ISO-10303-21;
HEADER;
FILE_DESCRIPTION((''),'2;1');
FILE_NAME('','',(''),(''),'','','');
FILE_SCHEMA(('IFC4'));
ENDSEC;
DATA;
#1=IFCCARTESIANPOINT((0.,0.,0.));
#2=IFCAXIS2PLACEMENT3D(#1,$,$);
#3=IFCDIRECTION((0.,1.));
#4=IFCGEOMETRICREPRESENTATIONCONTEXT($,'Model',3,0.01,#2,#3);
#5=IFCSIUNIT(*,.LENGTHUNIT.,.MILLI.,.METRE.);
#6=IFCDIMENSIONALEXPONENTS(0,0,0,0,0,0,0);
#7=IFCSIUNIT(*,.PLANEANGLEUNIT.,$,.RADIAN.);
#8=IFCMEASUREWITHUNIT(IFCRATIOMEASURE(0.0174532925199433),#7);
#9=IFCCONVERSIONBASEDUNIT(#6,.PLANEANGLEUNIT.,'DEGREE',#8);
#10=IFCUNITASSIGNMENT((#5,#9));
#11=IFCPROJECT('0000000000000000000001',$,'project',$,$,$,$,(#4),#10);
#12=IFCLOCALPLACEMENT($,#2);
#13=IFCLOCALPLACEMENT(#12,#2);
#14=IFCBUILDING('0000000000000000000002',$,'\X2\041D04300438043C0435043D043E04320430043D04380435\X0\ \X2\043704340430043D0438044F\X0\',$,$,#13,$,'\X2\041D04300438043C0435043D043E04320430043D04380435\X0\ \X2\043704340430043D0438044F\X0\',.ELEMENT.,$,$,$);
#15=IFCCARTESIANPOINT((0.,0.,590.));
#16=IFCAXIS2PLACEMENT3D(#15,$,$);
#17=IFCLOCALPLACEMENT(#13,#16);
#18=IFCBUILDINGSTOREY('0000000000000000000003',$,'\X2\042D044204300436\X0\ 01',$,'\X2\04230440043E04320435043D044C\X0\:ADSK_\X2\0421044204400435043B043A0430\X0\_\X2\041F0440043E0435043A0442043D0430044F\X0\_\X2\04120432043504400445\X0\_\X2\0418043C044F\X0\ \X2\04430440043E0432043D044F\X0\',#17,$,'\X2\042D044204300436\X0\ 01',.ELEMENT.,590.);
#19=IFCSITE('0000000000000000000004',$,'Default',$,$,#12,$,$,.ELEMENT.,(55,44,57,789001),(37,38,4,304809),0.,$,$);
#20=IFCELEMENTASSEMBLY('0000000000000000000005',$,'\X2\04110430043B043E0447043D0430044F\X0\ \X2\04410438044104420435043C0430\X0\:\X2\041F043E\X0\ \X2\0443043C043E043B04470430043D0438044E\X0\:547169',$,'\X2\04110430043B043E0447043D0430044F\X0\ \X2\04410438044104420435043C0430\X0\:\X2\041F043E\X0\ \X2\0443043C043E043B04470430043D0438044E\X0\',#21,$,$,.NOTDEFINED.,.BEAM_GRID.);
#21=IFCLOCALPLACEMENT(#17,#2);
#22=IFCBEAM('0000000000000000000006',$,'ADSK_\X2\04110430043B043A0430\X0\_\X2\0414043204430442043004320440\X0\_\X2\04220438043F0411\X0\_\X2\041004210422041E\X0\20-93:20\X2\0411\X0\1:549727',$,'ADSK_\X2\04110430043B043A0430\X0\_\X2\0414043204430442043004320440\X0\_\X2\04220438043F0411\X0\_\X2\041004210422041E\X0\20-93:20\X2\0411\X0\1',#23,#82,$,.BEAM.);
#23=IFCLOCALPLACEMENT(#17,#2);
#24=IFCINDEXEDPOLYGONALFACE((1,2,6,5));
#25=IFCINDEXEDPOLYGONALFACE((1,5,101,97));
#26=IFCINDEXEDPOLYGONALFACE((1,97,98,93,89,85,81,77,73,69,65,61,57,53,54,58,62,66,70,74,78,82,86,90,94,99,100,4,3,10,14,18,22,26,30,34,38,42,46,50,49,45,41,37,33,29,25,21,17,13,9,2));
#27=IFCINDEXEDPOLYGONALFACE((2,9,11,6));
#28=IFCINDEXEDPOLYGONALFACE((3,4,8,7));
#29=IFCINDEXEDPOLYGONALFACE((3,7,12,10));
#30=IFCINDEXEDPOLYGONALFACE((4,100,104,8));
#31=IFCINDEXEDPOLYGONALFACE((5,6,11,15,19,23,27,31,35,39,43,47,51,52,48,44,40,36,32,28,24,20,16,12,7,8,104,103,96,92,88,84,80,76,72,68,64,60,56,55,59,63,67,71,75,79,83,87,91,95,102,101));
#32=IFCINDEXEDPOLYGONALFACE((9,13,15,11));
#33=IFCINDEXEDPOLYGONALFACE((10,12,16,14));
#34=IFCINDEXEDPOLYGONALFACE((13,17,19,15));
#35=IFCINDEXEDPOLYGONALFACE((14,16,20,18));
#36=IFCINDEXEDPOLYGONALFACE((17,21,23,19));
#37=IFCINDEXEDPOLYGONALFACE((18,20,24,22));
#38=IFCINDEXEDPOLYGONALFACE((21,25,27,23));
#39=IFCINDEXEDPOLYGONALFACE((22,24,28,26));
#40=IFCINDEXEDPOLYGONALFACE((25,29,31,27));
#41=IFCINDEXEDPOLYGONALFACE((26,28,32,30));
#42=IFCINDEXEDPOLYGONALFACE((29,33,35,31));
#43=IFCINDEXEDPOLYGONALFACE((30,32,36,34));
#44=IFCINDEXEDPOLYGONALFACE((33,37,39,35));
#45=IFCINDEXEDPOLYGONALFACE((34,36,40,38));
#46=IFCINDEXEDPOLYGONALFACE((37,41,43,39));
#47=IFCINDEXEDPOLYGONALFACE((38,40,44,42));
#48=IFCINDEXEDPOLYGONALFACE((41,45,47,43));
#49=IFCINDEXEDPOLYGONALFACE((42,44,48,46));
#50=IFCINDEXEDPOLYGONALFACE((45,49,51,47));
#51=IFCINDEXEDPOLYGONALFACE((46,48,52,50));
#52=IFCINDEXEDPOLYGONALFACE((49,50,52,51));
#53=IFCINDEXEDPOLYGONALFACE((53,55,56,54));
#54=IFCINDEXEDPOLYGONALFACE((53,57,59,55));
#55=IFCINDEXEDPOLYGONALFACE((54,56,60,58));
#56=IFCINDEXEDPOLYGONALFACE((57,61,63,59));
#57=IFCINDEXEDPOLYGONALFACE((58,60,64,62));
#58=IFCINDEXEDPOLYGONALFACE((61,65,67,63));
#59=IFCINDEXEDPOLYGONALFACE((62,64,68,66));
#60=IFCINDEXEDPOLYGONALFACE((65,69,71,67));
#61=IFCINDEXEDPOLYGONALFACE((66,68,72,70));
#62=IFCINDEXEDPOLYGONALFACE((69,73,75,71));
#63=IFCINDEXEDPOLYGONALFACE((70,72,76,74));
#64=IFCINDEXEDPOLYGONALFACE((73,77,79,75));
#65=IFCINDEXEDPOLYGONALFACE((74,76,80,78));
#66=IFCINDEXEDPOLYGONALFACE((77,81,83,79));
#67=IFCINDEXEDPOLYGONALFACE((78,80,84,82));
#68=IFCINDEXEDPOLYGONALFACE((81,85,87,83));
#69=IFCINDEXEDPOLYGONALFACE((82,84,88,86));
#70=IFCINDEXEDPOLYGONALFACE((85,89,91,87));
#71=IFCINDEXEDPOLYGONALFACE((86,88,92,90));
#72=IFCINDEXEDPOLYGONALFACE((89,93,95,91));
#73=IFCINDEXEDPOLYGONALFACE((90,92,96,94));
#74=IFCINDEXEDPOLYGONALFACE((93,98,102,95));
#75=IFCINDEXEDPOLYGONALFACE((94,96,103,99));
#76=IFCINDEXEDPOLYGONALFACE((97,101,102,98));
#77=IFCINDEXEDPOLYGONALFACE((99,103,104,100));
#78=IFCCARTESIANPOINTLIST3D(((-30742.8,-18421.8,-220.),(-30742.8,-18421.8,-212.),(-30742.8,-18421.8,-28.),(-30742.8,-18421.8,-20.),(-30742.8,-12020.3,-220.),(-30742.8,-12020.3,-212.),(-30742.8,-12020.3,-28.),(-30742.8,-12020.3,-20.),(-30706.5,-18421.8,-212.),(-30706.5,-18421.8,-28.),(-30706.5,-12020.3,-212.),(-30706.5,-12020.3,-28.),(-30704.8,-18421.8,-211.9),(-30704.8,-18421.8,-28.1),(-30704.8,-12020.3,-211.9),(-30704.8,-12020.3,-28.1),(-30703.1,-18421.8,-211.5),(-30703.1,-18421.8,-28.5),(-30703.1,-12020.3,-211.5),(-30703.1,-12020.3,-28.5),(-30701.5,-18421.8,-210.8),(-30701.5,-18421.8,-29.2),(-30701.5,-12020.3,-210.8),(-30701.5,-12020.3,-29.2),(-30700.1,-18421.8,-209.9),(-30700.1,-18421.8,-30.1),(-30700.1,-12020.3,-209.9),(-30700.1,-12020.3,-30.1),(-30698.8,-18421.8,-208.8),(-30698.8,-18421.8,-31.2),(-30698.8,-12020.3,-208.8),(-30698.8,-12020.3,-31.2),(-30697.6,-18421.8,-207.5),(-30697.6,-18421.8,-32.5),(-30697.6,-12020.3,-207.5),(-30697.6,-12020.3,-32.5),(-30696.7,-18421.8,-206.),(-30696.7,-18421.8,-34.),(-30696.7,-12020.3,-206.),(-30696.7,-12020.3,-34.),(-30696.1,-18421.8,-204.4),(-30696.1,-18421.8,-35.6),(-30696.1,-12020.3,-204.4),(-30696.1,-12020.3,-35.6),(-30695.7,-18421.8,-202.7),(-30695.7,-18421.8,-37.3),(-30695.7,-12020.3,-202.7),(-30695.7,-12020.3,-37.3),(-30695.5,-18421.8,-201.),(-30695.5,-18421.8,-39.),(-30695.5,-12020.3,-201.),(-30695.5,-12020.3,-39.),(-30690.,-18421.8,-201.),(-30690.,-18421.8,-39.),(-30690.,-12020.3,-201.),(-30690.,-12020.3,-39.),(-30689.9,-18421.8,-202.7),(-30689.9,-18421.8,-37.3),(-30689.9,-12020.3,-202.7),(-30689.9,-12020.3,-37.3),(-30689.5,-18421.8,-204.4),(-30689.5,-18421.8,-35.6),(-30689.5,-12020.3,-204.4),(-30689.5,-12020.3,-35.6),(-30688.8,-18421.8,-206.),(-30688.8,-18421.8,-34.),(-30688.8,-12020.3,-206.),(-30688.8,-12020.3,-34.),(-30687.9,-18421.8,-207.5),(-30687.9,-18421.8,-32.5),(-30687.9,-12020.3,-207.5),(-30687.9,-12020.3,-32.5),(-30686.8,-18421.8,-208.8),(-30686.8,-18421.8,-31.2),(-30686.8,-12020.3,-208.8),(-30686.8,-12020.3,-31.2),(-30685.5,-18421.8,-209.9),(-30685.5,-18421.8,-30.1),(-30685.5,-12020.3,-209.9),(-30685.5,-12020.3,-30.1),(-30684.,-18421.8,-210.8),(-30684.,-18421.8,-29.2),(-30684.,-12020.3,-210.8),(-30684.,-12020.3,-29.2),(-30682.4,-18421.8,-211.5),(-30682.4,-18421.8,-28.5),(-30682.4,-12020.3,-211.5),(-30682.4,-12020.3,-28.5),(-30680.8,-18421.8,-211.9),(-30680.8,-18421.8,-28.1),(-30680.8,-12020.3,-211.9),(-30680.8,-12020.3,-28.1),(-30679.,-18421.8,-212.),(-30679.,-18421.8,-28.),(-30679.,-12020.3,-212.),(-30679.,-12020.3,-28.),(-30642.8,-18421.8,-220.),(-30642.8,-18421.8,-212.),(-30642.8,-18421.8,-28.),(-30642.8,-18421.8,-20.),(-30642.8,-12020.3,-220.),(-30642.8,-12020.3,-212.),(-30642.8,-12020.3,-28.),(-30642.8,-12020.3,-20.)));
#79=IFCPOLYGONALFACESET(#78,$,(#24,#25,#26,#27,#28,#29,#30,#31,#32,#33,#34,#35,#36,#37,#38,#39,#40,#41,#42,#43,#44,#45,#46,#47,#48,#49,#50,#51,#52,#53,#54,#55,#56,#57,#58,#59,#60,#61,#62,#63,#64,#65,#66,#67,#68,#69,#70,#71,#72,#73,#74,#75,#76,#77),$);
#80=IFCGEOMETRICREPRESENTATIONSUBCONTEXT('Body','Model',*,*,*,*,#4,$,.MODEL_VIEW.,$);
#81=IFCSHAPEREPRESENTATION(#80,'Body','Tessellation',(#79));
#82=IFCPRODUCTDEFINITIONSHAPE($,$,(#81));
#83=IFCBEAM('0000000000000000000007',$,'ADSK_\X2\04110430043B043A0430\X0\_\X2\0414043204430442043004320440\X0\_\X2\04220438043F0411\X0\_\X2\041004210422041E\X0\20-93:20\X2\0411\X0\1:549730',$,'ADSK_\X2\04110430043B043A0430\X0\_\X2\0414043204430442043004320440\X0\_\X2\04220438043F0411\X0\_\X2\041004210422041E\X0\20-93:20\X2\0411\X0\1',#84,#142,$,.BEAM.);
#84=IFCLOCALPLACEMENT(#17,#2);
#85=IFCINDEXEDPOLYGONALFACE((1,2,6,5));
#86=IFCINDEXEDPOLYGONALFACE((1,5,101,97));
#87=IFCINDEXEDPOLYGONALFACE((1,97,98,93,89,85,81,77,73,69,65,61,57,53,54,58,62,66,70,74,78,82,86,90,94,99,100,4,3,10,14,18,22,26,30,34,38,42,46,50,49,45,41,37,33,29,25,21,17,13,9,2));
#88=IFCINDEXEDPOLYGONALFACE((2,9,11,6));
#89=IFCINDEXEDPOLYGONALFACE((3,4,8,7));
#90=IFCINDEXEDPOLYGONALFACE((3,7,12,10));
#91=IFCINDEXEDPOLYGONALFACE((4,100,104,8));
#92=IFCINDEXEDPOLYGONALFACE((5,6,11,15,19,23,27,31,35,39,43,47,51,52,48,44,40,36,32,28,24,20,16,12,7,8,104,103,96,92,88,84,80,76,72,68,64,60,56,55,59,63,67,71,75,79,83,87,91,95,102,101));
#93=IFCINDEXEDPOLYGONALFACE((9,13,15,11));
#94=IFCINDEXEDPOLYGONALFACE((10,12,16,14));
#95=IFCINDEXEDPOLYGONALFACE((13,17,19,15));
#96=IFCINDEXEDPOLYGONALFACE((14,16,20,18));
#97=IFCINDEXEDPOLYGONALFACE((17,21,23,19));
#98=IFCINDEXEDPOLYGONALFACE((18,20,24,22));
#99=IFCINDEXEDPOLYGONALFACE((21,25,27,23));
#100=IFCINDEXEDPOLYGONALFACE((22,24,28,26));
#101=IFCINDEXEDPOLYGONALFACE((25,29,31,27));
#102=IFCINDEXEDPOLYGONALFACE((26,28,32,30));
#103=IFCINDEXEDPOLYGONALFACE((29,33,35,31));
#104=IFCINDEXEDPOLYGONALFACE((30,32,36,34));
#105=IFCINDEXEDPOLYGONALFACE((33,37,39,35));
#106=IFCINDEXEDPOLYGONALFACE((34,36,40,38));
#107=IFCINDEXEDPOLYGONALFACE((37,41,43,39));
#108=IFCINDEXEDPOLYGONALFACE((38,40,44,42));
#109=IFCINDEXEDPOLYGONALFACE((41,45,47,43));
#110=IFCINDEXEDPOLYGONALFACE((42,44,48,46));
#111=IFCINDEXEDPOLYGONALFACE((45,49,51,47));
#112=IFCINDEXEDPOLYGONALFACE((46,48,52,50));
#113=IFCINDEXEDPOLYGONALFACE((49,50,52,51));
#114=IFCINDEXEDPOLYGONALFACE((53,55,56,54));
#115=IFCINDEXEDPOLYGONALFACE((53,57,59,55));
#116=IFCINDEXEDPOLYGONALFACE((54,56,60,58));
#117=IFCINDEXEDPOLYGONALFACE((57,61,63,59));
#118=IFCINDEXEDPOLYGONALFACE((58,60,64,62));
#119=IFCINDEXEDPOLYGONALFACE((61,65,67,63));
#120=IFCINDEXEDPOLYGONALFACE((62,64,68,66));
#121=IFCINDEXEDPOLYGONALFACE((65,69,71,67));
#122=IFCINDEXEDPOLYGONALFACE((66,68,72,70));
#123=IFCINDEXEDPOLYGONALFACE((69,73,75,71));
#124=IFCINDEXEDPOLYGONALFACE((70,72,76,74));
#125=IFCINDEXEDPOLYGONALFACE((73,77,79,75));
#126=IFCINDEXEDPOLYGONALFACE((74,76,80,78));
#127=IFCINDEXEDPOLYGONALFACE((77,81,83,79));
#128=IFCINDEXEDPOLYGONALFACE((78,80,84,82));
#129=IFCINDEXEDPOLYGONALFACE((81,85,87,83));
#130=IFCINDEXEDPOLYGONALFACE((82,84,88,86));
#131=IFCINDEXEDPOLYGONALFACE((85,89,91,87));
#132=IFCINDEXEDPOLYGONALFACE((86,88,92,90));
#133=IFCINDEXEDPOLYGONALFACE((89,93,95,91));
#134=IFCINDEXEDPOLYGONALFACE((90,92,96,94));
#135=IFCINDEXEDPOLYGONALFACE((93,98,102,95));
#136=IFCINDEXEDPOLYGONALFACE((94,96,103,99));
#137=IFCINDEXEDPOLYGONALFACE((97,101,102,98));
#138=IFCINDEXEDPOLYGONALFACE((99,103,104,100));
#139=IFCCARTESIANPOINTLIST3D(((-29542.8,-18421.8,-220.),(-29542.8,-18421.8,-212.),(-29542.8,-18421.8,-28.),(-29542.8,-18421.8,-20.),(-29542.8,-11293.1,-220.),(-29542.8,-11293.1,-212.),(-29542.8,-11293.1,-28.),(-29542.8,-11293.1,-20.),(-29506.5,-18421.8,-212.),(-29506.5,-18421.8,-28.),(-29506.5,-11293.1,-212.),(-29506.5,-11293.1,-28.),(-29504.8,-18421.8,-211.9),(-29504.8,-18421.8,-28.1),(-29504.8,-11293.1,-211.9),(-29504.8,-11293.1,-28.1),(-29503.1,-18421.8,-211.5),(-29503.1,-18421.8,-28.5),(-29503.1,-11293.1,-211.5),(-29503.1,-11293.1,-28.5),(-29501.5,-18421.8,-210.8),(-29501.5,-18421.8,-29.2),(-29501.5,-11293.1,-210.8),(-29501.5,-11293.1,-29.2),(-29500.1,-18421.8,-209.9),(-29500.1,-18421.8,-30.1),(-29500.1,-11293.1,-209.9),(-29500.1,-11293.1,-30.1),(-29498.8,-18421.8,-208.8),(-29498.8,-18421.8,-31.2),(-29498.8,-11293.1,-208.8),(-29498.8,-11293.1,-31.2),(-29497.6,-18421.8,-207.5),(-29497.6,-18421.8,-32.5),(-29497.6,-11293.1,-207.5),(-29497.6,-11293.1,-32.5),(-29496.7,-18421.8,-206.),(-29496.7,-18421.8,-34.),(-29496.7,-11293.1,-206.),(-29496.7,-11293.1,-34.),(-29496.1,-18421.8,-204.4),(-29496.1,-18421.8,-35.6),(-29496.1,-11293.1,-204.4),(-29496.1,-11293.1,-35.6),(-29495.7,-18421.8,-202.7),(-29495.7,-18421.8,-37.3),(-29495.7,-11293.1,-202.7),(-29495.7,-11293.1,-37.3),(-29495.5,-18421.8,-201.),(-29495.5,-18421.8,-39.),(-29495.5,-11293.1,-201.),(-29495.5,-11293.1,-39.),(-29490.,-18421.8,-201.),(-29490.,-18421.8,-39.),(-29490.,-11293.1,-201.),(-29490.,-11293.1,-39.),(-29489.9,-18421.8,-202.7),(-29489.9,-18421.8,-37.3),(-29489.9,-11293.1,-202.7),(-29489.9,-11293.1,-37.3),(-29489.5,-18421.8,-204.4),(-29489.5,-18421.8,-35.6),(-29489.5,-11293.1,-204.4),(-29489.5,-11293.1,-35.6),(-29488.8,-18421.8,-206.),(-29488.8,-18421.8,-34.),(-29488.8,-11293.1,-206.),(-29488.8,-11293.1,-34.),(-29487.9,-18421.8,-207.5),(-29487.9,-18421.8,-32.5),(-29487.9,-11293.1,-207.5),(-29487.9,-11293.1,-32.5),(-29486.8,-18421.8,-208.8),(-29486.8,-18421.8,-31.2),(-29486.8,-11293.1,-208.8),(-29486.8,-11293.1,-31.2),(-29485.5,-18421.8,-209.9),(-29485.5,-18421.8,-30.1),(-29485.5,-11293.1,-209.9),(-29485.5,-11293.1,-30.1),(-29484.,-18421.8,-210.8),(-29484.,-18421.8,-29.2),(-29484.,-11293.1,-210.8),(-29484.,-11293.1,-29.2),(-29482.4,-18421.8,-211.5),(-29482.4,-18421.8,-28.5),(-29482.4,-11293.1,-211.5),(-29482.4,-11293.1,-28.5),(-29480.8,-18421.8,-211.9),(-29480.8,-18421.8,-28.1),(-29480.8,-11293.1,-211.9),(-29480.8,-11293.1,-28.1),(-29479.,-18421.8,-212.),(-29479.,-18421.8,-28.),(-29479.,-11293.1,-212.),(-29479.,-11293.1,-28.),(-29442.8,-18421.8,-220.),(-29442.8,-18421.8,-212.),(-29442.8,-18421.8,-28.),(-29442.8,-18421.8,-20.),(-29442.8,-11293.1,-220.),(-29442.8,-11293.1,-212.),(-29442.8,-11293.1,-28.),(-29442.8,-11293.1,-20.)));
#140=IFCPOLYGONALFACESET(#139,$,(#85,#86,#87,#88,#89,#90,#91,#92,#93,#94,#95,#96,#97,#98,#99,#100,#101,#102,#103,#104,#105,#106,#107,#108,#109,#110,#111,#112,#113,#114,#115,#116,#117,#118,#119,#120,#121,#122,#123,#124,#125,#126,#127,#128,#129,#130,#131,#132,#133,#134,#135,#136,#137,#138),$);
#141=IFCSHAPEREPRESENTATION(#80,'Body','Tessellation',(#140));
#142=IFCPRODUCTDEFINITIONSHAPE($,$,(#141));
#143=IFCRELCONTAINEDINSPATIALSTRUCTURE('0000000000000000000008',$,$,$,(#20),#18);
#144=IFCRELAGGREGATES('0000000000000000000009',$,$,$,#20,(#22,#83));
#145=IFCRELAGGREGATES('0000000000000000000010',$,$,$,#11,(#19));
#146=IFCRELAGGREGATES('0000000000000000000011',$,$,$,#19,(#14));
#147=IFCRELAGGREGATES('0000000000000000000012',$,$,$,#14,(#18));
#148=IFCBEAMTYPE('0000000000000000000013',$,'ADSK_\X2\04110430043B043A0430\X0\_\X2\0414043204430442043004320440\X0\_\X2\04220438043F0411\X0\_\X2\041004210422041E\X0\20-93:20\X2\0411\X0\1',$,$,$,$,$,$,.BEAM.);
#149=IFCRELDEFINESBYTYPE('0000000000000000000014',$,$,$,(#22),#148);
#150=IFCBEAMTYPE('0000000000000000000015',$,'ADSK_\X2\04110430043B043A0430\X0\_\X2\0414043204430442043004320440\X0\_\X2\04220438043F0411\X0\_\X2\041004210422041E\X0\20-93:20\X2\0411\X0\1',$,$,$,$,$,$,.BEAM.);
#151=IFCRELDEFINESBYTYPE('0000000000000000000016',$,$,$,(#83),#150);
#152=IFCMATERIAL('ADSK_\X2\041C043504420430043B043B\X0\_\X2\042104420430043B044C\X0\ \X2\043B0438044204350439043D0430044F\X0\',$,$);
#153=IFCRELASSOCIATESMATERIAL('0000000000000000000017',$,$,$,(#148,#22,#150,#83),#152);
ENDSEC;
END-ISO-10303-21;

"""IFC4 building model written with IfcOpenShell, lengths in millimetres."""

from ifc_helpers import new_model, entity, si_unit, converted_unit, direction, frame, origin, place, context, subcontext, project, spatial, indexed_curve, outline, extrude, source, transform, mapped, material, type_object, type_shapes, element, aggregate, save


model = new_model("IFC4")

# Units and contexts
model_context = context("Model", 3, precision=0.01, world=origin(), true_north=direction((0.0, 1.0)))
body_context = subcontext(model_context, "Body", "Model", "MODEL_VIEW")
ifc_project = project(units=[si_unit("LENGTHUNIT", "METRE", prefix="MILLI"), converted_unit("PLANEANGLEUNIT", "DEGREE", entity("IfcRatioMeasure", 0.0174532925199433), si_unit("PLANEANGLEUNIT", "RADIAN"), dimensions=[0, 0, 0, 0, 0, 0, 0])], contexts=[model_context])

# Site, building, storey
site_placement = place(None, origin())
site = spatial("IfcSite", under=ifc_project, at=site_placement, Name="Default", CompositionType="ELEMENT", RefLatitude=(55, 44, 57, 789001), RefLongitude=(37, 38, 4, 304809), RefElevation=0.0)
building_placement = place(site_placement, origin())
building = spatial("IfcBuilding", under=site, at=building_placement, Name="Наименование здания", LongName="Наименование здания", CompositionType="ELEMENT")
storey_placement = place(building_placement, frame((0.0, 0.0, 590.0)))
storey = spatial("IfcBuildingStorey", under=building, at=storey_placement, Name="Этаж 01", ObjectType="Уровень:ADSK_Стрелка_Проектная_Вверх_Имя уровня", LongName="Этаж 01", CompositionType="ELEMENT", Elevation=590.0)

# Element assembly, beams
assembly_placement = place(storey_placement, origin())
assembly = element("IfcElementAssembly", 1, at=assembly_placement, inside=storey, Name="Балочная система:По умолчанию:547169", ObjectType="Балочная система:По умолчанию", AssemblyPlace="NOTDEFINED", PredefinedType="BEAM_GRID")
ifc_material_1 = material(Name="ADSK_Металл_Сталь литейная")
beam_type_1 = type_object("IfcBeamType", Name="ADSK_Балка_Двутавр_ТипБ_АСТО20-93:20Б1", PredefinedType="BEAM", material=ifc_material_1)
shared_shape_1 = source(origin(), body_context, "Body", "SweptSolid", [
    extrude(outline(indexed_curve([(-100.0, -50.0), (-92.0, -50.0), (-92.0, -13.8), (-91.9, -12.0), (-91.5, -10.4), (-90.8, -8.8), (-89.9, -7.3), (-88.8, -6.0), (-87.5, -4.9), (-86.0, -3.9), (-84.4, -3.3), (-82.7, -2.9), (-81.0, -2.8), (81.0, -2.8), (82.7, -2.9), (84.4, -3.3), (86.0, -3.9), (87.5, -4.9), (88.8, -6.0), (89.9, -7.3), (90.8, -8.8), (91.5, -10.4), (91.9, -12.0), (92.0, -13.7), (92.0, -50.0), (100.0, -50.0), (100.0, 50.0), (92.0, 50.0), (92.0, 13.8), (91.9, 12.0), (91.5, 10.4), (90.8, 8.8), (89.9, 7.3), (88.8, 6.0), (87.5, 4.9), (86.0, 3.9), (84.4, 3.3), (82.7, 2.9), (81.0, 2.8), (-81.0, 2.8), (-82.7, 2.9), (-84.4, 3.3), (-86.0, 3.9), (-87.5, 4.9), (-88.8, 6.0), (-89.9, 7.3), (-90.8, 8.8), (-91.5, 10.4), (-91.9, 12.0), (-92.0, 13.8), (-92.0, 50.0), (-100.0, 50.0), (-100.0, -50.0)], self_intersect=False)), frame((-3200.8, 0.0, -100.0), z_axis=(1.0, 0.0, 0.0), x_axis=(0.0, 0.0, -1.0)), (0.0, 0.0, 1.0), 6401.5),
])
type_shapes(beam_type_1, [shared_shape_1])
beam_1_placement = place(assembly_placement, frame((-30692.8, -15221.0, -20.0), z_axis=(0.0, 0.0, 1.0), x_axis=(0.0, 1.0, 0.0)))
beam_1 = element("IfcBeam", 2, at=beam_1_placement, type_object=beam_type_1, material=ifc_material_1, Name="ADSK_Балка_Двутавр_ТипБ_АСТО20-93:20Б1:549727", ObjectType="ADSK_Балка_Двутавр_ТипБ_АСТО20-93:20Б1", PredefinedType="BEAM", context=body_context, shape_type="MappedRepresentation", body=[
    mapped(shared_shape_1, transform((0.0, 0.0, 0.0), scale=1.0)),
])
beam_type_2 = type_object("IfcBeamType", Name="ADSK_Балка_Двутавр_ТипБ_АСТО20-93:20Б1", PredefinedType="BEAM", material=ifc_material_1)
shared_shape_2 = source(origin(), body_context, "Body", "SweptSolid", [
    extrude(outline(indexed_curve([(-100.0, -50.0), (-92.0, -50.0), (-92.0, -13.8), (-91.9, -12.0), (-91.5, -10.4), (-90.8, -8.8), (-89.9, -7.3), (-88.8, -6.0), (-87.5, -4.9), (-86.0, -3.9), (-84.4, -3.3), (-82.7, -2.9), (-81.0, -2.8), (81.0, -2.8), (82.7, -2.9), (84.4, -3.3), (86.0, -3.9), (87.5, -4.9), (88.8, -6.0), (89.9, -7.3), (90.8, -8.8), (91.5, -10.4), (91.9, -12.0), (92.0, -13.7), (92.0, -50.0), (100.0, -50.0), (100.0, 50.0), (92.0, 50.0), (92.0, 13.8), (91.9, 12.0), (91.5, 10.4), (90.8, 8.8), (89.9, 7.3), (88.8, 6.0), (87.5, 4.9), (86.0, 3.9), (84.4, 3.3), (82.7, 2.9), (81.0, 2.8), (-81.0, 2.8), (-82.7, 2.9), (-84.4, 3.3), (-86.0, 3.9), (-87.5, 4.9), (-88.8, 6.0), (-89.9, 7.3), (-90.8, 8.8), (-91.5, 10.4), (-91.9, 12.0), (-92.0, 13.8), (-92.0, 50.0), (-100.0, 50.0), (-100.0, -50.0)], self_intersect=False)), frame((-3564.3, 0.0, -100.0), z_axis=(1.0, 0.0, 0.0), x_axis=(0.0, 0.0, -1.0)), (0.0, 0.0, 1.0), 7128.7),
])
type_shapes(beam_type_2, [shared_shape_2])
beam_2_placement = place(assembly_placement, frame((-29492.8, -14857.5, -20.0), z_axis=(0.0, 0.0, 1.0), x_axis=(0.0, 1.0, 0.0)))
beam_2 = element("IfcBeam", 3, at=beam_2_placement, type_object=beam_type_2, material=ifc_material_1, Name="ADSK_Балка_Двутавр_ТипБ_АСТО20-93:20Б1:549730", ObjectType="ADSK_Балка_Двутавр_ТипБ_АСТО20-93:20Б1", PredefinedType="BEAM", context=body_context, shape_type="MappedRepresentation", body=[
    mapped(shared_shape_2, transform((0.0, 0.0, 0.0), scale=1.0)),
])
aggregate(assembly, [beam_1, beam_2])

save(model, "model.ifc")
